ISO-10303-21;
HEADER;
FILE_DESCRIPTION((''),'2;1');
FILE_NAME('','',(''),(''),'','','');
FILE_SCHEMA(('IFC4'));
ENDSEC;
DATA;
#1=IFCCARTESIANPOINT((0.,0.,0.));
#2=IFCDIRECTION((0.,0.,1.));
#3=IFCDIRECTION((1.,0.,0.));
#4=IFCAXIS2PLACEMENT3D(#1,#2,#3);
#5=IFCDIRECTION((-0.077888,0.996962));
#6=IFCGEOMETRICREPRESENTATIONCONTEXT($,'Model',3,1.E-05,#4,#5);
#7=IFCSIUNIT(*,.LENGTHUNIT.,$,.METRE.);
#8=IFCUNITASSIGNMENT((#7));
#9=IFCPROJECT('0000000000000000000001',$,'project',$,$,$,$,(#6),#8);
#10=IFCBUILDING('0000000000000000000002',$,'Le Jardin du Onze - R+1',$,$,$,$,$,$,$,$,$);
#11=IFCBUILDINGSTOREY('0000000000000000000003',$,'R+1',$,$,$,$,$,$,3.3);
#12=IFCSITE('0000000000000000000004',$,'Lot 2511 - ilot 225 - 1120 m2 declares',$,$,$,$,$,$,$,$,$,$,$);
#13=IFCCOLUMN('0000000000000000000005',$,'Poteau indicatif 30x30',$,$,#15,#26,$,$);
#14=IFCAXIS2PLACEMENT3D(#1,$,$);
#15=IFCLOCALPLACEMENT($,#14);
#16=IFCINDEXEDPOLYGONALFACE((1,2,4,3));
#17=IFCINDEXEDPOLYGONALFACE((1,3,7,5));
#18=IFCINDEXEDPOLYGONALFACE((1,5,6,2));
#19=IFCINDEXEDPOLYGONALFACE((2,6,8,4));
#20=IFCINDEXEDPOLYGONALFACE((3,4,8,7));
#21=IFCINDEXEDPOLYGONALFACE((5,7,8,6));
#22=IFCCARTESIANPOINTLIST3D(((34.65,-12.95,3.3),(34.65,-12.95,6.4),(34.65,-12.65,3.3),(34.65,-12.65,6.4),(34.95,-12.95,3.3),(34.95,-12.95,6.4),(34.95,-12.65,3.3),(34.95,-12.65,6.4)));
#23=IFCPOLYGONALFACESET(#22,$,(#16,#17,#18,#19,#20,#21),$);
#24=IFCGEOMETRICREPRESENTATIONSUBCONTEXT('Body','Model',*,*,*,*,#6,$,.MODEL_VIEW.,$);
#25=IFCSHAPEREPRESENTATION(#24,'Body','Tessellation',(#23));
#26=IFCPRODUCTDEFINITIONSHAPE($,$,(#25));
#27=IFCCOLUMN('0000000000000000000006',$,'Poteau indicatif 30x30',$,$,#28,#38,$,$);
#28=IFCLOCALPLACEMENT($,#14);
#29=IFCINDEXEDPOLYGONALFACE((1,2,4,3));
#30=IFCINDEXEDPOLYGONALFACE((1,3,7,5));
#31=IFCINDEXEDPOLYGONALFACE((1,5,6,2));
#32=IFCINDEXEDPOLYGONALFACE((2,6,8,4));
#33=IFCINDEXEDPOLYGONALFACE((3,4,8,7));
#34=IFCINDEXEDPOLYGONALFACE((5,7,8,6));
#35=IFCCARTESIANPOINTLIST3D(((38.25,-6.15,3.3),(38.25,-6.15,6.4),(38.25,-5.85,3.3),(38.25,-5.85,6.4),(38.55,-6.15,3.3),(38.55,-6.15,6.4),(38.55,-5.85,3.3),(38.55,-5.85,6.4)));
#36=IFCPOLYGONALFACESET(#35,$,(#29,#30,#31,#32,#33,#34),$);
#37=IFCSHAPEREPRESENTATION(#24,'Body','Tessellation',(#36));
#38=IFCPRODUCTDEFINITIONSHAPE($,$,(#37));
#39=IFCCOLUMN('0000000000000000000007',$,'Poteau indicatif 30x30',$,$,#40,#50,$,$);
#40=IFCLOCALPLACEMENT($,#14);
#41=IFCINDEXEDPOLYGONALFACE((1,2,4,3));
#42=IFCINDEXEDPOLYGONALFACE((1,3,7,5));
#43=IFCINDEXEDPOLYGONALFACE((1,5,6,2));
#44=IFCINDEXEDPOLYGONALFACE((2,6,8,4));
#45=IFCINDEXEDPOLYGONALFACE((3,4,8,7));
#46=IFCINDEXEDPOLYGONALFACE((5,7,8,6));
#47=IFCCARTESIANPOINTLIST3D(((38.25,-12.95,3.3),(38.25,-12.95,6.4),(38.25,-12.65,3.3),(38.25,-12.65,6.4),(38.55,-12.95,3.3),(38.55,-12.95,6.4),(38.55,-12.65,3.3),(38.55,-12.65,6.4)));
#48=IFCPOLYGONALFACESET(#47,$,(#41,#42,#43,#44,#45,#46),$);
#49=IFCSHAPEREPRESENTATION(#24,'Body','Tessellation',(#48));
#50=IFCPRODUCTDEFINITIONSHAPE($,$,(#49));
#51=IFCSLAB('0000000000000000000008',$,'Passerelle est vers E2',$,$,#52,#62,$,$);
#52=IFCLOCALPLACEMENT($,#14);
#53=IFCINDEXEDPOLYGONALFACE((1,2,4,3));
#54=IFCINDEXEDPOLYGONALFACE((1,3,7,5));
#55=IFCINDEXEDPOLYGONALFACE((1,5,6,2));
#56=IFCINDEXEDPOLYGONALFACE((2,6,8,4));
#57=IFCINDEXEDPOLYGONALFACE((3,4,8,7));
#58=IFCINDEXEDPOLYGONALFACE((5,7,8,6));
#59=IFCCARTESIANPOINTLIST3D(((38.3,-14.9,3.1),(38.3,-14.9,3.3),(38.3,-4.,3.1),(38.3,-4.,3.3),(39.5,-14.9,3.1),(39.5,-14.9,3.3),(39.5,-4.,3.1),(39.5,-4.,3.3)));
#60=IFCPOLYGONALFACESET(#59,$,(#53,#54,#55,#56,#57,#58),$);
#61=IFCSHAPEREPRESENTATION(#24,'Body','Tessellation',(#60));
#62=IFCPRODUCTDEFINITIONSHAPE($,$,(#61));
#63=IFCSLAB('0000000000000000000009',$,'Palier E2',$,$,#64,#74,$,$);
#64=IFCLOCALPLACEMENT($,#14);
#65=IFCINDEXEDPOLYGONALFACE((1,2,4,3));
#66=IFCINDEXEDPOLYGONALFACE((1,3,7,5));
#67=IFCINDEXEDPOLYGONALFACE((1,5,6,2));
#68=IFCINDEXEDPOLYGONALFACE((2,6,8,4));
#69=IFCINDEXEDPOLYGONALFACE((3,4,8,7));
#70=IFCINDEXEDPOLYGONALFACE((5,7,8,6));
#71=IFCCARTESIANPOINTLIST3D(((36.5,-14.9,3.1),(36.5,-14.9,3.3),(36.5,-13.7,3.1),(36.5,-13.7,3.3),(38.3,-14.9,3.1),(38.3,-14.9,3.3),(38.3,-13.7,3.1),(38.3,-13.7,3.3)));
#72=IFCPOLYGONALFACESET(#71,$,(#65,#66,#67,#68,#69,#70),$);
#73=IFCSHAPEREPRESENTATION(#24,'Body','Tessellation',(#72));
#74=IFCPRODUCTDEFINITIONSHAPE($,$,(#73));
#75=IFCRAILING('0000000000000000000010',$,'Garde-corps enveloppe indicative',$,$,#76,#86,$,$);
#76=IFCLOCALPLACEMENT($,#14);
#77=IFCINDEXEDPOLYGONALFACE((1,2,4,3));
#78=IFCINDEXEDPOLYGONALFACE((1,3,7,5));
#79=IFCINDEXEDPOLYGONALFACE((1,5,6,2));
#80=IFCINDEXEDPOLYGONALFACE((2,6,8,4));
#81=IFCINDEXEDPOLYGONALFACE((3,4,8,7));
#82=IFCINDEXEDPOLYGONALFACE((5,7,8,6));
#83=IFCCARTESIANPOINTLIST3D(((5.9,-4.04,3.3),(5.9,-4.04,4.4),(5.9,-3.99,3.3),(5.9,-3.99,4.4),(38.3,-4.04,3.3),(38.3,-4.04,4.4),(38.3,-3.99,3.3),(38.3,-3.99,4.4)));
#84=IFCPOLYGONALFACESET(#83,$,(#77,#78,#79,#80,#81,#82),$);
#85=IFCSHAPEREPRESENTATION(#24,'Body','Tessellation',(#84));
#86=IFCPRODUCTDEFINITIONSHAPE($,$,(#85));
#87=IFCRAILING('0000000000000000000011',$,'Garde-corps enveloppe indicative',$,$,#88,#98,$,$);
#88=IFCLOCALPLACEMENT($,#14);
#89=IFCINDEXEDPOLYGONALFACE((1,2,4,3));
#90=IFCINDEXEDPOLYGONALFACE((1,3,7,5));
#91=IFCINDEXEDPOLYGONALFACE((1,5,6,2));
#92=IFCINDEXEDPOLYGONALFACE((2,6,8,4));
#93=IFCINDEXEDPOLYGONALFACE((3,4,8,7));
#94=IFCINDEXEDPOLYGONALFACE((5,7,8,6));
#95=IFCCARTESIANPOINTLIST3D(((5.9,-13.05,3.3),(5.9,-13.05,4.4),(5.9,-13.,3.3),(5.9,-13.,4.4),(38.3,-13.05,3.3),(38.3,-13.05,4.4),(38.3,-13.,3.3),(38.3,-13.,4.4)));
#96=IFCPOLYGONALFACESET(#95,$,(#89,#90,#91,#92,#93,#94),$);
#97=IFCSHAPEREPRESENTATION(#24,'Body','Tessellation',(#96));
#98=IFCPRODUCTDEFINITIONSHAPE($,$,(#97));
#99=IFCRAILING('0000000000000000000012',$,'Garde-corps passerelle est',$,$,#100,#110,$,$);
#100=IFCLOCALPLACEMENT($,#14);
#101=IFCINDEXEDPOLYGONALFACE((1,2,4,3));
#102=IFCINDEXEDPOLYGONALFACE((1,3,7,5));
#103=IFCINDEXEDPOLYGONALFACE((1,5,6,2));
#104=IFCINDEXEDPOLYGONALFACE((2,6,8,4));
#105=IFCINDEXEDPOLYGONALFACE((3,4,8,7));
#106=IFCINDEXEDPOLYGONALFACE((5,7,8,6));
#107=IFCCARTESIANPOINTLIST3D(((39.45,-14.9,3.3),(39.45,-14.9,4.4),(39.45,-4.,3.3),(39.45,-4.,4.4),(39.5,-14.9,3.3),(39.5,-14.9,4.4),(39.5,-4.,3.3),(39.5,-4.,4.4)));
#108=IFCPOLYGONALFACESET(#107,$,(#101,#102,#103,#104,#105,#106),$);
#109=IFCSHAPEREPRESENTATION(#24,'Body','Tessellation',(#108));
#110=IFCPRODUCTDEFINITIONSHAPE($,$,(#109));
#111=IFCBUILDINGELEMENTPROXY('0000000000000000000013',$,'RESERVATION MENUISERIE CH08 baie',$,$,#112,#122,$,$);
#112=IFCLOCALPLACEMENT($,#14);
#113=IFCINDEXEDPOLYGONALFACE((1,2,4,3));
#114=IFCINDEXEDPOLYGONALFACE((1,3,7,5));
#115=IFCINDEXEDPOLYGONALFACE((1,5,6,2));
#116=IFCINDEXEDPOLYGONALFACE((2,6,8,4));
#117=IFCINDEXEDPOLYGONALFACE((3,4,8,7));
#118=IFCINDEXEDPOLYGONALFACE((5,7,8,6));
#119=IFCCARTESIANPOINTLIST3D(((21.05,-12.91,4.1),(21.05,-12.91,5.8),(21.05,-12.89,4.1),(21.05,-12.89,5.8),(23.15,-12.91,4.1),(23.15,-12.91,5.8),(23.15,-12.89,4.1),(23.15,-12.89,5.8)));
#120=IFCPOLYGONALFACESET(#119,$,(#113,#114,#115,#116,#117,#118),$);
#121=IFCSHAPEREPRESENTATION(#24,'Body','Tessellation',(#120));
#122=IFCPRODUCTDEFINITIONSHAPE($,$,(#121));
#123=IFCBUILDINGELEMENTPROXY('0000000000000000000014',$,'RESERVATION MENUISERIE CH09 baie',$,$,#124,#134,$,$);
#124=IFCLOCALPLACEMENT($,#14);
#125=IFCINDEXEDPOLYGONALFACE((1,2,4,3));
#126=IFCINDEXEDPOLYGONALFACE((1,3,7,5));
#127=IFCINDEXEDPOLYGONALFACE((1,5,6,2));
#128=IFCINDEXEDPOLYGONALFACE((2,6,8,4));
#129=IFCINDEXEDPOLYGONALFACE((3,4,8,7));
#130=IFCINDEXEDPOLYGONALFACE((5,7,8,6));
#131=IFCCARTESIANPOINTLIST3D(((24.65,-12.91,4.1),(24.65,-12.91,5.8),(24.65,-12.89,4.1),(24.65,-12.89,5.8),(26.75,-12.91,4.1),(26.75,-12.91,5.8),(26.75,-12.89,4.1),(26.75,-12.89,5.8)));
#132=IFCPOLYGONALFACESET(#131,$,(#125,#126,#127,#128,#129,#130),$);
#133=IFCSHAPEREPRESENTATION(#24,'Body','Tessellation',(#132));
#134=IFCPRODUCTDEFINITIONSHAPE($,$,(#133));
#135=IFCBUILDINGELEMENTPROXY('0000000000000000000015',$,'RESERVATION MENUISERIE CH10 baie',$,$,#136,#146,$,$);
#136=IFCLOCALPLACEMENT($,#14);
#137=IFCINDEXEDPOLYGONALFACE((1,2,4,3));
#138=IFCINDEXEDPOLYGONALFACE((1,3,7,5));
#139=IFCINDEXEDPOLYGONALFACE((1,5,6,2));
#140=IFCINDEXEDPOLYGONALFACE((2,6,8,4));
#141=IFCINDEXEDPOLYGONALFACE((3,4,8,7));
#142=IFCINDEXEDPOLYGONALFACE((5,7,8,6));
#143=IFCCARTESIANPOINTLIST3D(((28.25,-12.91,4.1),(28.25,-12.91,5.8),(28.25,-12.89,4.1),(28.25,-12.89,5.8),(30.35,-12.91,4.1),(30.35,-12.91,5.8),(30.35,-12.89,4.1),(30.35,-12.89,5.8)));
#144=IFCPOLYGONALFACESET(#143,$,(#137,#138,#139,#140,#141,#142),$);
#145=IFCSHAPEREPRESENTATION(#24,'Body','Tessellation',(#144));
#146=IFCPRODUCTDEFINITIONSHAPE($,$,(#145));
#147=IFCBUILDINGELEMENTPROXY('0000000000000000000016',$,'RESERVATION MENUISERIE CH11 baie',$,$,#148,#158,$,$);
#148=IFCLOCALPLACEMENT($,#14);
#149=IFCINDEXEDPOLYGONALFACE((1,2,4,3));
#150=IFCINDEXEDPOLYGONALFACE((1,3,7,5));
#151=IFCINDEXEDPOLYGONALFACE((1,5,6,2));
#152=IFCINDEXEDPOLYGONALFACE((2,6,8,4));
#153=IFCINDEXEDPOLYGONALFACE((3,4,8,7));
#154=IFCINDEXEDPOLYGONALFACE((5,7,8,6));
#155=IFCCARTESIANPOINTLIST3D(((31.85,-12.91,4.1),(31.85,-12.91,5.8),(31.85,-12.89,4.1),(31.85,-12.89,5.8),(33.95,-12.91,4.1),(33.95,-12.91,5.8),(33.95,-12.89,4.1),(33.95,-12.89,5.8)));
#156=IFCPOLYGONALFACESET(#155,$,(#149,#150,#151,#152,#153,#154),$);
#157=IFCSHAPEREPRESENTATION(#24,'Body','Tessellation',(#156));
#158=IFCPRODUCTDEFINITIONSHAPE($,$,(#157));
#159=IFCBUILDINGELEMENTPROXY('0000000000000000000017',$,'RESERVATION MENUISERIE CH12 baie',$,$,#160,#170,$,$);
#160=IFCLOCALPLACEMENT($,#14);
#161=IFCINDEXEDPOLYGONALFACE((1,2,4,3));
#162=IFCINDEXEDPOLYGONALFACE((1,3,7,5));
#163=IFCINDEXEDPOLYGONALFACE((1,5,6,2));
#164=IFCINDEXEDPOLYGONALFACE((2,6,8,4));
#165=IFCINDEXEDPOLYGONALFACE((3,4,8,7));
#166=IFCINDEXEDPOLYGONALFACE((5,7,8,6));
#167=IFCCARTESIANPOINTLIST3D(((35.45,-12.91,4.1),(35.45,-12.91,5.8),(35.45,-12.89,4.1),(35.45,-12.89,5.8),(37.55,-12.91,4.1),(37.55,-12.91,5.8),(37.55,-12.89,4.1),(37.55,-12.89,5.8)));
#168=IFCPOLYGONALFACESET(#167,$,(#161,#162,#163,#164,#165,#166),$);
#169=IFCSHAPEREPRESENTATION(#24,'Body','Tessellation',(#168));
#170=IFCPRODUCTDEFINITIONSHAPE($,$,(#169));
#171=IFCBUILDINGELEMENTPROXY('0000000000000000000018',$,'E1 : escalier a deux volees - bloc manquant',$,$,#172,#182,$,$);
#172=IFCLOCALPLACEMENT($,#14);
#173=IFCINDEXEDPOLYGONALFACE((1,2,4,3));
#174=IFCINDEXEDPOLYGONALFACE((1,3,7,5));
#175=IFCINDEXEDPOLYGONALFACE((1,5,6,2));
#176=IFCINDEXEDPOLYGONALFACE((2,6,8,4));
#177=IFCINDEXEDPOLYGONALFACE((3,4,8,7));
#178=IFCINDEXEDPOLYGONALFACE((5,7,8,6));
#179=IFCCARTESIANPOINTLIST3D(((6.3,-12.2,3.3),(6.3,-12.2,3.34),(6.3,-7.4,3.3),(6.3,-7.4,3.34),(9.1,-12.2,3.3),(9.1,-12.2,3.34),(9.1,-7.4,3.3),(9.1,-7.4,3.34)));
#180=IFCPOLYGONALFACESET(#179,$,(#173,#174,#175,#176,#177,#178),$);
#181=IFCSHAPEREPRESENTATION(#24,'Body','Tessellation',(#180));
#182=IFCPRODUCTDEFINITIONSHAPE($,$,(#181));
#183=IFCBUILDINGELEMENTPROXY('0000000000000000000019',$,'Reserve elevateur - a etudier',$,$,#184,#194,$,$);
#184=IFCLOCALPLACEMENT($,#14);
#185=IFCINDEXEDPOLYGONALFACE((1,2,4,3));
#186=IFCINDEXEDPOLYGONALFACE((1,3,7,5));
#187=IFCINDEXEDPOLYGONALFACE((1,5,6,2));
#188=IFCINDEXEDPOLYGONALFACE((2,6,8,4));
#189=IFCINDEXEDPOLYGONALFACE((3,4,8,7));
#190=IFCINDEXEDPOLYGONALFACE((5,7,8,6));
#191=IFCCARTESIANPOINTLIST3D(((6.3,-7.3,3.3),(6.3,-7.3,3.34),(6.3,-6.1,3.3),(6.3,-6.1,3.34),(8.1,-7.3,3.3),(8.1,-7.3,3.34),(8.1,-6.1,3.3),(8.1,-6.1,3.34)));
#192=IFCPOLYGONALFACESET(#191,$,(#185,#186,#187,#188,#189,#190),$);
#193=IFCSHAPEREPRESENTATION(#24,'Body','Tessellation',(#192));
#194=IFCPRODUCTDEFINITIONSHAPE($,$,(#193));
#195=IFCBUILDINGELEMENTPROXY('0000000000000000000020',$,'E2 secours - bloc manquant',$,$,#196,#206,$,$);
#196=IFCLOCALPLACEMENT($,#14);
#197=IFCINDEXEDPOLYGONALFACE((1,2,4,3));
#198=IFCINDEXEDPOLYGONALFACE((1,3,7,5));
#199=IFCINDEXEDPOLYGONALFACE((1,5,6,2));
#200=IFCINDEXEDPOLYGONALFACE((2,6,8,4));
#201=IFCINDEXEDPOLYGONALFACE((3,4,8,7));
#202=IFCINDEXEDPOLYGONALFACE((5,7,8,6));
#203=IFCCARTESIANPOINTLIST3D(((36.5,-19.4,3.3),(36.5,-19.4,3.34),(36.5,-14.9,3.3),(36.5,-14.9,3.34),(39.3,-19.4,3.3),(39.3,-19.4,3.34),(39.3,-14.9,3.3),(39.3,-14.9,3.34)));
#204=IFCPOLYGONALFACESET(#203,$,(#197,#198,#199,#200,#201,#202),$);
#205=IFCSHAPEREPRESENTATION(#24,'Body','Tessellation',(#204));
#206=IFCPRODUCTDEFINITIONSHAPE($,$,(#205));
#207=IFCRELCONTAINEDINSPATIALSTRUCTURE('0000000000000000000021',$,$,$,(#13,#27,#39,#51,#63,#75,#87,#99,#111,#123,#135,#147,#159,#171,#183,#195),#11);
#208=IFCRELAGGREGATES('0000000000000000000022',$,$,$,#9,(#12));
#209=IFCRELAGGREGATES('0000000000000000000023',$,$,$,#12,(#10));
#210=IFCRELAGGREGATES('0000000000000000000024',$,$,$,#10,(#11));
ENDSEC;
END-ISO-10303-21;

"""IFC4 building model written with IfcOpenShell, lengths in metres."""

from ifc_helpers import new_model, si_unit, direction, frame, origin_with_axes, place, context, subcontext, project, spatial, polyline, outline, extrude, element, save


model = new_model("IFC4")

# Units and contexts
model_context = context("Model", 3, precision=1e-05, world=origin_with_axes(), true_north=direction((-0.077888, 0.996962)))
body_context = subcontext(model_context, "Body", "Model", "MODEL_VIEW")
ifc_project = project(units=[si_unit("LENGTHUNIT", "METRE")], contexts=[model_context])

# Site, building, storey
site = spatial("IfcSite", under=ifc_project, Name="Lot 2511 - ilot 225 - 1120 m2 declares")
building = spatial("IfcBuilding", under=site, Name="Le Jardin du Onze - R+1")
storey = spatial("IfcBuildingStorey", under=building, Name="R+1", Elevation=3.3)

# Columns
column_1_placement = place(None, origin_with_axes())
element("IfcColumn", 1, at=column_1_placement, inside=storey, Name="Poteau indicatif 30x30", context=body_context, shape_type="SweptSolid", body=[
    extrude(outline(polyline([(34.95, -12.95), (34.95, -12.65), (34.65, -12.65), (34.65, -12.95), (34.95, -12.95)])), frame((0.0, 0.0, 3.3)), (0.0, 0.0, 1.0), 3.1),
])
column_2_placement = place(None, origin_with_axes())
element("IfcColumn", 2, at=column_2_placement, inside=storey, Name="Poteau indicatif 30x30", context=body_context, shape_type="SweptSolid", body=[
    extrude(outline(polyline([(38.55, -6.15), (38.55, -5.85), (38.25, -5.85), (38.25, -6.15), (38.55, -6.15)])), frame((0.0, 0.0, 3.3)), (0.0, 0.0, 1.0), 3.1),
])
column_3_placement = place(None, origin_with_axes())
element("IfcColumn", 3, at=column_3_placement, inside=storey, Name="Poteau indicatif 30x30", context=body_context, shape_type="SweptSolid", body=[
    extrude(outline(polyline([(38.55, -12.95), (38.55, -12.65), (38.25, -12.65), (38.25, -12.95), (38.55, -12.95)])), frame((0.0, 0.0, 3.3)), (0.0, 0.0, 1.0), 3.1),
])

# Slabs
slab_1_placement = place(None, origin_with_axes())
element("IfcSlab", 4, at=slab_1_placement, inside=storey, Name="Passerelle est vers E2", context=body_context, shape_type="SweptSolid", body=[
    extrude(outline(polyline([(39.5, -14.9), (39.5, -4.0), (38.3, -4.0), (38.3, -14.9), (39.5, -14.9)])), frame((0.0, 0.0, 3.1)), (0.0, 0.0, 1.0), 0.2),
])
slab_2_placement = place(None, origin_with_axes())
element("IfcSlab", 5, at=slab_2_placement, inside=storey, Name="Palier E2", context=body_context, shape_type="SweptSolid", body=[
    extrude(outline(polyline([(38.3, -14.9), (38.3, -13.7), (36.5, -13.7), (36.5, -14.9), (38.3, -14.9)])), frame((0.0, 0.0, 3.1)), (0.0, 0.0, 1.0), 0.2),
])

# Railings
railing_1_placement = place(None, origin_with_axes())
element("IfcRailing", 6, at=railing_1_placement, inside=storey, Name="Garde-corps enveloppe indicative", context=body_context, shape_type="SweptSolid", body=[
    extrude(outline(polyline([(38.3, -4.04), (38.3, -3.99), (5.9, -3.99), (5.9, -4.04), (38.3, -4.04)])), frame((0.0, 0.0, 3.3)), (0.0, 0.0, 1.0), 1.1),
])
railing_2_placement = place(None, origin_with_axes())
element("IfcRailing", 7, at=railing_2_placement, inside=storey, Name="Garde-corps enveloppe indicative", context=body_context, shape_type="SweptSolid", body=[
    extrude(outline(polyline([(38.3, -13.05), (38.3, -13.0), (5.9, -13.0), (5.9, -13.05), (38.3, -13.05)])), frame((0.0, 0.0, 3.3)), (0.0, 0.0, 1.0), 1.1),
])
railing_3_placement = place(None, origin_with_axes())
element("IfcRailing", 8, at=railing_3_placement, inside=storey, Name="Garde-corps passerelle est", context=body_context, shape_type="SweptSolid", body=[
    extrude(outline(polyline([(39.5, -14.9), (39.5, -4.0), (39.45, -4.0), (39.45, -14.9), (39.5, -14.9)])), frame((0.0, 0.0, 3.3)), (0.0, 0.0, 1.0), 1.1),
])

# Building element proxies
proxy_1_placement = place(None, origin_with_axes())
element("IfcBuildingElementProxy", 9, at=proxy_1_placement, inside=storey, Name="RESERVATION MENUISERIE CH08 baie", context=body_context, shape_type="SweptSolid", body=[
    extrude(outline(polyline([(23.15, -12.91), (23.15, -12.89), (21.05, -12.89), (21.05, -12.91), (23.15, -12.91)])), frame((0.0, 0.0, 4.1)), (0.0, 0.0, 1.0), 1.7),
])
proxy_2_placement = place(None, origin_with_axes())
element("IfcBuildingElementProxy", 10, at=proxy_2_placement, inside=storey, Name="RESERVATION MENUISERIE CH09 baie", context=body_context, shape_type="SweptSolid", body=[
    extrude(outline(polyline([(26.75, -12.91), (26.75, -12.89), (24.65, -12.89), (24.65, -12.91), (26.75, -12.91)])), frame((0.0, 0.0, 4.1)), (0.0, 0.0, 1.0), 1.7),
])
proxy_3_placement = place(None, origin_with_axes())
element("IfcBuildingElementProxy", 11, at=proxy_3_placement, inside=storey, Name="RESERVATION MENUISERIE CH10 baie", context=body_context, shape_type="SweptSolid", body=[
    extrude(outline(polyline([(30.35, -12.91), (30.35, -12.89), (28.25, -12.89), (28.25, -12.91), (30.35, -12.91)])), frame((0.0, 0.0, 4.1)), (0.0, 0.0, 1.0), 1.7),
])
proxy_4_placement = place(None, origin_with_axes())
element("IfcBuildingElementProxy", 12, at=proxy_4_placement, inside=storey, Name="RESERVATION MENUISERIE CH11 baie", context=body_context, shape_type="SweptSolid", body=[
    extrude(outline(polyline([(33.95, -12.91), (33.95, -12.89), (31.85, -12.89), (31.85, -12.91), (33.95, -12.91)])), frame((0.0, 0.0, 4.1)), (0.0, 0.0, 1.0), 1.7),
])
proxy_5_placement = place(None, origin_with_axes())
element("IfcBuildingElementProxy", 13, at=proxy_5_placement, inside=storey, Name="RESERVATION MENUISERIE CH12 baie", context=body_context, shape_type="SweptSolid", body=[
    extrude(outline(polyline([(37.55, -12.91), (37.55, -12.89), (35.45, -12.89), (35.45, -12.91), (37.55, -12.91)])), frame((0.0, 0.0, 4.1)), (0.0, 0.0, 1.0), 1.7),
])
proxy_6_placement = place(None, origin_with_axes())
element("IfcBuildingElementProxy", 14, at=proxy_6_placement, inside=storey, Name="E1 : escalier a deux volees - bloc manquant", context=body_context, shape_type="SweptSolid", body=[
    extrude(outline(polyline([(9.1, -12.2), (9.1, -7.4), (6.3, -7.4), (6.3, -12.2), (9.1, -12.2)])), frame((0.0, 0.0, 3.3)), (0.0, 0.0, 1.0), 0.04),
])
proxy_7_placement = place(None, origin_with_axes())
element("IfcBuildingElementProxy", 15, at=proxy_7_placement, inside=storey, Name="Reserve elevateur - a etudier", context=body_context, shape_type="SweptSolid", body=[
    extrude(outline(polyline([(8.1, -7.3), (8.1, -6.1), (6.3, -6.1), (6.3, -7.3), (8.1, -7.3)])), frame((0.0, 0.0, 3.3)), (0.0, 0.0, 1.0), 0.04),
])
proxy_8_placement = place(None, origin_with_axes())
element("IfcBuildingElementProxy", 16, at=proxy_8_placement, inside=storey, Name="E2 secours - bloc manquant", context=body_context, shape_type="SweptSolid", body=[
    extrude(outline(polyline([(39.3, -19.4), (39.3, -14.9), (36.5, -14.9), (36.5, -19.4), (39.3, -19.4)])), frame((0.0, 0.0, 3.3)), (0.0, 0.0, 1.0), 0.04),
])

save(model, "model.ifc")
